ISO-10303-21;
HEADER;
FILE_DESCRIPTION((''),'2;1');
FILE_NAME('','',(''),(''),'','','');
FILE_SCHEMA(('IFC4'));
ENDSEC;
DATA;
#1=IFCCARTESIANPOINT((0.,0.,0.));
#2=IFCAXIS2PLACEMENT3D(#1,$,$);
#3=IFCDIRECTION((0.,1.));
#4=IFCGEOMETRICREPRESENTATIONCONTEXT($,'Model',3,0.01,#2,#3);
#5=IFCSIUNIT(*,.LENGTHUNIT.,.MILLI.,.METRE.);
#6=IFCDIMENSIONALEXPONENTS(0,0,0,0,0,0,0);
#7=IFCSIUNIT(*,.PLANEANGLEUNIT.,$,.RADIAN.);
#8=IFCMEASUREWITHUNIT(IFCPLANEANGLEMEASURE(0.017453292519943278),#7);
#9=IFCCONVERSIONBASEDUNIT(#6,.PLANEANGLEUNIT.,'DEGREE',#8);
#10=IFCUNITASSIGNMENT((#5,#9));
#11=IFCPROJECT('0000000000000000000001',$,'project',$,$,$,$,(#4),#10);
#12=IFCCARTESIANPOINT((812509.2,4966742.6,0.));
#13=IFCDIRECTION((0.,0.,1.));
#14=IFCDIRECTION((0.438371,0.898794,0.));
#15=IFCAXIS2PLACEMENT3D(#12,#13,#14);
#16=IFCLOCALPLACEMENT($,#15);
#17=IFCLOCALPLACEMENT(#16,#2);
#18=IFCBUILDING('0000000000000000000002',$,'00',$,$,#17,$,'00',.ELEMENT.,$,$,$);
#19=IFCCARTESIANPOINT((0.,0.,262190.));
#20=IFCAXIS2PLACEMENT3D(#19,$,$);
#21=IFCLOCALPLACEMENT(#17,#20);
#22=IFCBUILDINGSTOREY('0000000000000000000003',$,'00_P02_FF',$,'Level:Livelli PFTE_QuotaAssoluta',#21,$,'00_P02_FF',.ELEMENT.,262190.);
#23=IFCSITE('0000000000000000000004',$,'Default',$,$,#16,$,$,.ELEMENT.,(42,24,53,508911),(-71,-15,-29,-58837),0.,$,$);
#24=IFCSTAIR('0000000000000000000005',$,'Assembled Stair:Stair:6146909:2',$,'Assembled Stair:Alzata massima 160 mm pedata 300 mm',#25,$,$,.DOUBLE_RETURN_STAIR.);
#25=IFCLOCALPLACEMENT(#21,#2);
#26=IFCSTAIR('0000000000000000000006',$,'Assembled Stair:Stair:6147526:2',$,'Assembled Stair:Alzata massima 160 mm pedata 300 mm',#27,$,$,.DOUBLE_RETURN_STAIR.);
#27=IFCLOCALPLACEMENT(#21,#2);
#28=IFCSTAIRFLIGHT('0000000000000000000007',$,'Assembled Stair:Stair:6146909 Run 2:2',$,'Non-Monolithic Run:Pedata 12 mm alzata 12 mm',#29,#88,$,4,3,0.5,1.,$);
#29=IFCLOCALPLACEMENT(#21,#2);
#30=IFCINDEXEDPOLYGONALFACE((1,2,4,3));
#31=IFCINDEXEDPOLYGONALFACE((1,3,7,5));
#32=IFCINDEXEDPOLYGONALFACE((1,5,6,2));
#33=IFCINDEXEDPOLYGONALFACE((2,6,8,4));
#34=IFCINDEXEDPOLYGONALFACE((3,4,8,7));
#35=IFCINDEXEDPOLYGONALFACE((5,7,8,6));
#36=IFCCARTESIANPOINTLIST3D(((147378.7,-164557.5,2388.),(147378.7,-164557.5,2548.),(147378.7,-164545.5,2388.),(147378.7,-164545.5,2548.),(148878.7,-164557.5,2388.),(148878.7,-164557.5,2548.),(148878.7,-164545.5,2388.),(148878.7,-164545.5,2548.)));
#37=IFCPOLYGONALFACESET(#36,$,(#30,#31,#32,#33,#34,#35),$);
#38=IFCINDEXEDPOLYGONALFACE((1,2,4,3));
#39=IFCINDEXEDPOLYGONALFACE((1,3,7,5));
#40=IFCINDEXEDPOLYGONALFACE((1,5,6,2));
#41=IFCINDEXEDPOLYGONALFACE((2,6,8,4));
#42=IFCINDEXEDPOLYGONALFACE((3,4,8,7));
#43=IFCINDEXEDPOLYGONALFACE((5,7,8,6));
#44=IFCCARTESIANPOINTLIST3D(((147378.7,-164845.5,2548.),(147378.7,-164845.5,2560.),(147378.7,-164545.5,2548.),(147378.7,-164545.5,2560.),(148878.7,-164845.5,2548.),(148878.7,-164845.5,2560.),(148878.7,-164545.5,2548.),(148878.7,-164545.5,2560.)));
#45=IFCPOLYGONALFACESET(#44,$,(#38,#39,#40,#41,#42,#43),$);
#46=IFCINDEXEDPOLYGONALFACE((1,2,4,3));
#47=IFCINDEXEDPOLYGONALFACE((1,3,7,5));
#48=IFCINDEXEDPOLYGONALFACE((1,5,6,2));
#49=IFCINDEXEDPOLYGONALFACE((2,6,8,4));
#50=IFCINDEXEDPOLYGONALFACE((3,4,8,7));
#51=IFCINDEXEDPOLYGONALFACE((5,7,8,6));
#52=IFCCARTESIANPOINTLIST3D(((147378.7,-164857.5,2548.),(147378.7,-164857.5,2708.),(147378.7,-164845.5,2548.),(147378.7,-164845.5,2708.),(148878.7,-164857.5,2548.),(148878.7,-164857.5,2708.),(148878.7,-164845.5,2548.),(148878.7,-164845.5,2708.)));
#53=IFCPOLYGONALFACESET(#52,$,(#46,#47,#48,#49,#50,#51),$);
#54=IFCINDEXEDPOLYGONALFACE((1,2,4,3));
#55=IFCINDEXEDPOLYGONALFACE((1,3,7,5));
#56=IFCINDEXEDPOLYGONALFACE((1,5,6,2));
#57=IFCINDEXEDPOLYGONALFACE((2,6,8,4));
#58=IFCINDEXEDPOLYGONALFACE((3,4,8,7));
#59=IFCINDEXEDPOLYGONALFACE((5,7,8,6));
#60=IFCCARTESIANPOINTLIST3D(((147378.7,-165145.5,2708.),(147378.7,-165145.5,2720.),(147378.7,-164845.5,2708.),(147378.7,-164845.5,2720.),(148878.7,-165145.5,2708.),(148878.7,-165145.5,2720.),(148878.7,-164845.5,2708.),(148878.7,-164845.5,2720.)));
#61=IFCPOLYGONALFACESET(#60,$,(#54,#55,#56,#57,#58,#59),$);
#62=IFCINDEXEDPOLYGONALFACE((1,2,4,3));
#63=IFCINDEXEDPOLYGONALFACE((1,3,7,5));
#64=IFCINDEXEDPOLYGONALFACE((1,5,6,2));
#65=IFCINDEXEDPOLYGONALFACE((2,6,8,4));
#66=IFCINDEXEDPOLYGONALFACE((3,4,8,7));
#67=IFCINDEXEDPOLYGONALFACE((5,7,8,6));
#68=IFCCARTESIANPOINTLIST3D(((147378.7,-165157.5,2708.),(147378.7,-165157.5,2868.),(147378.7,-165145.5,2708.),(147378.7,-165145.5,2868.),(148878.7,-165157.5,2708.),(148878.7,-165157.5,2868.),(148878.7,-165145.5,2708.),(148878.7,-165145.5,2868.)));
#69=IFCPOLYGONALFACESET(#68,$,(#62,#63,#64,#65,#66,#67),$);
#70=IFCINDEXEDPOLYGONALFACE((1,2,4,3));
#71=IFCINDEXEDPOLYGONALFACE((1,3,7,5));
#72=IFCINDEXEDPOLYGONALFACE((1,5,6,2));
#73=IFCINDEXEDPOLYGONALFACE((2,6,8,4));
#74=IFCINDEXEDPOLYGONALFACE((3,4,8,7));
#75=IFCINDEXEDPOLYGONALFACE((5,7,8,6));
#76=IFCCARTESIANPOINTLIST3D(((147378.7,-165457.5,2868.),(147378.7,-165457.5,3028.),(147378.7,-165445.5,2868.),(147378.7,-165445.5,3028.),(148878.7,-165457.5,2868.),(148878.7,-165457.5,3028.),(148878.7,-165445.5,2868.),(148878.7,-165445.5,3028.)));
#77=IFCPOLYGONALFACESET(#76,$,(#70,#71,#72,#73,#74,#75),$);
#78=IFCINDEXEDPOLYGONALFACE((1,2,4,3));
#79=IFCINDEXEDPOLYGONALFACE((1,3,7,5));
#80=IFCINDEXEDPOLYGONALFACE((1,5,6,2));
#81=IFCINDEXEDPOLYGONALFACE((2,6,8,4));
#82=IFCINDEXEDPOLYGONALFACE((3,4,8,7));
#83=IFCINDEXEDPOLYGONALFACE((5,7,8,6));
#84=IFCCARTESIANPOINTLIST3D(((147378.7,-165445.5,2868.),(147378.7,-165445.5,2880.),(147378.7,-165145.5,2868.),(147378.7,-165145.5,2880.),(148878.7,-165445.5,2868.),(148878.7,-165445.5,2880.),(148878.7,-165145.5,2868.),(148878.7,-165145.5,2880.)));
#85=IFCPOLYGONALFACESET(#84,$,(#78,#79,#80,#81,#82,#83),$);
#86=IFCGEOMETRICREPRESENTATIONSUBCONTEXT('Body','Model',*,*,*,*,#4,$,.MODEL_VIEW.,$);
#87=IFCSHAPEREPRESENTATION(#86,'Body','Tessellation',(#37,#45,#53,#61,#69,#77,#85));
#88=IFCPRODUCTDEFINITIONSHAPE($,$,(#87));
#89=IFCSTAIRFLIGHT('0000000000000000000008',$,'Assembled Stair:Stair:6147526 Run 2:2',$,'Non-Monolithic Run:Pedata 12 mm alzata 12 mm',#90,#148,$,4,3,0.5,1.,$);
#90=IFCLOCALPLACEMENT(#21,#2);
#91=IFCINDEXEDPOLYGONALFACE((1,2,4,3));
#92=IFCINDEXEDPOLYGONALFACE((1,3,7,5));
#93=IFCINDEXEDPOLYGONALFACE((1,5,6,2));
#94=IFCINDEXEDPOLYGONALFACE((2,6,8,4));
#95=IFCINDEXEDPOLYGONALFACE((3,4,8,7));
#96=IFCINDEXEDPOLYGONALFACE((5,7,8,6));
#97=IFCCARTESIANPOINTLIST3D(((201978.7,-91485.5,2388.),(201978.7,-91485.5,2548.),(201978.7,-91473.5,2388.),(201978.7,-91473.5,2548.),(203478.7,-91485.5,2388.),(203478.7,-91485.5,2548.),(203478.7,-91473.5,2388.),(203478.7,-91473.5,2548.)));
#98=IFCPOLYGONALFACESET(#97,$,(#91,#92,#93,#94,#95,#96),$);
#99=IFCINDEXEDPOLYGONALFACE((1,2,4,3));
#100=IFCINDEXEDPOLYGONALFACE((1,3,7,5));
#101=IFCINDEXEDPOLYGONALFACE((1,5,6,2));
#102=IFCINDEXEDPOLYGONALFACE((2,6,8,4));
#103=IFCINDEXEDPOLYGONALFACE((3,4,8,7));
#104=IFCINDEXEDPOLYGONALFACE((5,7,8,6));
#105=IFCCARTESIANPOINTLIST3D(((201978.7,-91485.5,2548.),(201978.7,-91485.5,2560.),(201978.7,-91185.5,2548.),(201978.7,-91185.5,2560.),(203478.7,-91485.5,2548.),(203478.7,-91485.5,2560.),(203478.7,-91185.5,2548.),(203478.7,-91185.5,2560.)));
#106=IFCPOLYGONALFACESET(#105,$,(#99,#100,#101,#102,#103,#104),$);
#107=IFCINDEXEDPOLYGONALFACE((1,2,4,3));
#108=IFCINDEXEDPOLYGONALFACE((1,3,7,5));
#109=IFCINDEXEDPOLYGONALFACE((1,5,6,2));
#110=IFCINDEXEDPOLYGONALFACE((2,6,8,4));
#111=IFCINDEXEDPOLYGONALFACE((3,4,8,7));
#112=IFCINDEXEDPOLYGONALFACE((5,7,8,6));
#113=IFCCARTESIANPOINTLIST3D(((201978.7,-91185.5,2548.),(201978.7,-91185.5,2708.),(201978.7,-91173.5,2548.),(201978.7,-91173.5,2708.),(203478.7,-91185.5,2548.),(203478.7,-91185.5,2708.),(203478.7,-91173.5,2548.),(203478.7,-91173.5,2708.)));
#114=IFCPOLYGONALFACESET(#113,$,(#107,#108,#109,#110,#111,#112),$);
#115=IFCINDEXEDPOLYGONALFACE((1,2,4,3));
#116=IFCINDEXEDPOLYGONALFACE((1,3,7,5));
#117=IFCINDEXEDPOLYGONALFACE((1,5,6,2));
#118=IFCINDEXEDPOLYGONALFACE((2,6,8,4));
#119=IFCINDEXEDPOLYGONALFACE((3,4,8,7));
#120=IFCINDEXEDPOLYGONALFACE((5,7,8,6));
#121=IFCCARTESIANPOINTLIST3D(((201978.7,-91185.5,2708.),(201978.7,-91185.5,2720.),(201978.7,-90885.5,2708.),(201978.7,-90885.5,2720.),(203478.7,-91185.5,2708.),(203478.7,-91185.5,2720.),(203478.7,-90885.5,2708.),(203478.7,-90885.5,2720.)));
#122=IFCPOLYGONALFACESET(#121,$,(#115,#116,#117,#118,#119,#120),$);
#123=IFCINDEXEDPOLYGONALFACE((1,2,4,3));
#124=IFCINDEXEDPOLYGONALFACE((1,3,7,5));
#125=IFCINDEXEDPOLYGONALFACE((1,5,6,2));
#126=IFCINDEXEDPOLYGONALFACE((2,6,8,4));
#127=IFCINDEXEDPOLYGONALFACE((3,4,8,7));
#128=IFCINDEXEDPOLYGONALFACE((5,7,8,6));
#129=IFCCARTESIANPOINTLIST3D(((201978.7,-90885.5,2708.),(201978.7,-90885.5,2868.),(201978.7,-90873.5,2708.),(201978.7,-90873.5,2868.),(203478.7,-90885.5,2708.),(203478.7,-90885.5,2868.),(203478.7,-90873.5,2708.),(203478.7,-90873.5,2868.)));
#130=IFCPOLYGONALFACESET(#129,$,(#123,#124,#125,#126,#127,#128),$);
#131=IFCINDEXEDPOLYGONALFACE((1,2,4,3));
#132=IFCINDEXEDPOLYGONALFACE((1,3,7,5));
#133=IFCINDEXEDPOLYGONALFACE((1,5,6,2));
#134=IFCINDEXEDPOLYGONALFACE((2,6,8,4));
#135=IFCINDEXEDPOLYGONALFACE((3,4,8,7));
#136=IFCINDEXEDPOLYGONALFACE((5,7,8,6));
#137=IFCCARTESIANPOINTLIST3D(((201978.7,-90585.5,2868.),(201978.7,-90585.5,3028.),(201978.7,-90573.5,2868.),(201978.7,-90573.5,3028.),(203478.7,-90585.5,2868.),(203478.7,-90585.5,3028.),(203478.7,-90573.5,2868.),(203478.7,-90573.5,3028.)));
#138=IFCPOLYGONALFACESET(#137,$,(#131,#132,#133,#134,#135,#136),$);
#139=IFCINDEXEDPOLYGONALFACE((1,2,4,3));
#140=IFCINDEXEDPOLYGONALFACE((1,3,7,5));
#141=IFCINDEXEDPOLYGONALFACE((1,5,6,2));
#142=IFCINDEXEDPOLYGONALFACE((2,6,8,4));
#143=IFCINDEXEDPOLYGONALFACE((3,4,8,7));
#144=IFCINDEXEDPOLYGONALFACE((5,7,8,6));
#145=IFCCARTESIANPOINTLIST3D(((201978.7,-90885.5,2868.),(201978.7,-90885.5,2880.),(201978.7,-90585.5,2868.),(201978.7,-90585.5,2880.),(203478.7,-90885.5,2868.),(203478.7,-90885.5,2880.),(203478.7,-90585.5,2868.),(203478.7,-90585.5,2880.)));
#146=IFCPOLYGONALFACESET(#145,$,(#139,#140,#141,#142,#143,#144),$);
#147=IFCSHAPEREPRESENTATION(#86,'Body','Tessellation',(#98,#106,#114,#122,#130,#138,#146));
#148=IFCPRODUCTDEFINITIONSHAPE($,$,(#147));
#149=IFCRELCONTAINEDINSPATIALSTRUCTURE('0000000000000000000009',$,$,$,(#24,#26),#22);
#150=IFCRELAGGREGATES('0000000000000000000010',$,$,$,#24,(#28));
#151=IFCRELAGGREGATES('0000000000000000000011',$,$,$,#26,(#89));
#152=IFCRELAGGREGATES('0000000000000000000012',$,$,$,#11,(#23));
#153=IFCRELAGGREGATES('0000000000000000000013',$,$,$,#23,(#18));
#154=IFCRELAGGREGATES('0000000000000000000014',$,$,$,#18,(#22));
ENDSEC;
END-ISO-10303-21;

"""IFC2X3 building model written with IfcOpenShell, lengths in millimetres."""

from ifc_helpers import new_model, entity, si_unit, converted_unit, direction, frame, frame_2d, origin, origin_2d_with_axis, place, context, subcontext, project, spatial, rectangle, extrude, element, aggregate, save


model = new_model("IFC2X3")

# Units and contexts
model_context = context("Model", 3, precision=0.01, world=origin(), true_north=direction((0.0, 1.0)))
body_context = subcontext(model_context, "Body", "Model", "MODEL_VIEW")
ifc_project = project(units=[si_unit("LENGTHUNIT", "METRE", prefix="MILLI"), converted_unit("PLANEANGLEUNIT", "DEGREE", entity("IfcPlaneAngleMeasure", 0.017453292519943278), si_unit("PLANEANGLEUNIT", "RADIAN"), dimensions=[0, 0, 0, 0, 0, 0, 0])], contexts=[model_context])

# Site, building, storey
site_placement = place(None, frame((812509.2, 4966742.6, 0.0), z_axis=(0.0, 0.0, 1.0), x_axis=(0.438371, 0.898794, 0.0)))
site = spatial("IfcSite", under=ifc_project, at=site_placement, Name="Default", CompositionType="ELEMENT", RefLatitude=(42, 24, 53, 508911), RefLongitude=(-71, -15, -29, -58837), RefElevation=0.0)
building_placement = place(site_placement, origin())
building = spatial("IfcBuilding", under=site, at=building_placement, Name="00", LongName="00", CompositionType="ELEMENT")
storey_placement = place(building_placement, frame((0.0, 0.0, 262190.0)))
storey = spatial("IfcBuildingStorey", under=building, at=storey_placement, Name="00_P02_FF", ObjectType="Level:Livelli PFTE_QuotaAssoluta", LongName="00_P02_FF", CompositionType="ELEMENT", Elevation=262190.0)

# Stairs
stair_1_placement = place(storey_placement, origin())
stair_1 = element("IfcStair", 1, at=stair_1_placement, inside=storey, Name="Assembled Stair:Stair:6146909:2", ObjectType="Assembled Stair:Alzata massima 160 mm pedata 300 mm", ShapeType="DOUBLE_RETURN_STAIR")
stair_2_placement = place(storey_placement, origin())
stair_2 = element("IfcStair", 2, at=stair_2_placement, inside=storey, Name="Assembled Stair:Stair:6147526:2", ObjectType="Assembled Stair:Alzata massima 160 mm pedata 300 mm", ShapeType="DOUBLE_RETURN_STAIR")

# Stair flights
stair_flight_1_placement = place(stair_1_placement, origin())
stair_flight_1 = element("IfcStairFlight", 3, at=stair_flight_1_placement, Name="Assembled Stair:Stair:6146909 Run 2:2", ObjectType="Non-Monolithic Run:Pedata 12 mm alzata 12 mm", NumberOfRiser=4, NumberOfTreads=3, RiserHeight=0.5, TreadLength=1.0, context=body_context, shape_type="SweptSolid", body=[
    extrude(rectangle(XDim=1500.0, YDim=12.0, at=origin_2d_with_axis()), frame((148128.7, -164551.5, 2388.0)), (0.0, 0.0, 1.0), 160.0),
    extrude(rectangle(XDim=300.0, YDim=1500.0, at=origin_2d_with_axis()), frame((148128.7, -164695.5, 2548.0), z_axis=(0.0, 0.0, 1.0), x_axis=(0.0, 1.0, 0.0)), (0.0, 0.0, 1.0), 12.0),
    extrude(rectangle(XDim=1500.0, YDim=12.0, at=origin_2d_with_axis()), frame((148128.7, -164851.5, 2548.0)), (0.0, 0.0, 1.0), 160.0),
    extrude(rectangle(XDim=300.0, YDim=1500.0, at=frame_2d((0.0, 0.0), x_axis=(1.0, 0.0))), frame((148128.7, -164995.5, 2708.0), z_axis=(0.0, 0.0, 1.0), x_axis=(0.0, 1.0, 0.0)), (0.0, 0.0, 1.0), 12.0),
    extrude(rectangle(XDim=1500.0, YDim=12.0, at=origin_2d_with_axis()), frame((148128.7, -165151.5, 2708.0)), (0.0, 0.0, 1.0), 160.0),
    extrude(rectangle(XDim=1500.0, YDim=12.0, at=origin_2d_with_axis()), frame((148128.7, -165451.5, 2868.0)), (0.0, 0.0, 1.0), 160.0),
    extrude(rectangle(XDim=300.0, YDim=1500.0, at=frame_2d((0.0, 0.0), x_axis=(1.0, 0.0))), frame((148128.7, -165295.5, 2868.0), z_axis=(0.0, 0.0, 1.0), x_axis=(0.0, 1.0, 0.0)), (0.0, 0.0, 1.0), 12.0),
])
aggregate(stair_1, [stair_flight_1])
stair_flight_2_placement = place(stair_2_placement, origin())
stair_flight_2 = element("IfcStairFlight", 4, at=stair_flight_2_placement, Name="Assembled Stair:Stair:6147526 Run 2:2", ObjectType="Non-Monolithic Run:Pedata 12 mm alzata 12 mm", NumberOfRiser=4, NumberOfTreads=3, RiserHeight=0.5, TreadLength=1.0, context=body_context, shape_type="SweptSolid", body=[
    extrude(rectangle(XDim=1500.0, YDim=12.0, at=origin_2d_with_axis()), frame((202728.7, -91479.5, 2388.0), z_axis=(0.0, 0.0, 1.0), x_axis=(-1.0, 0.0, 0.0)), (0.0, 0.0, 1.0), 160.0),
    extrude(rectangle(XDim=300.0, YDim=1500.0, at=origin_2d_with_axis()), frame((202728.7, -91335.5, 2548.0), z_axis=(0.0, 0.0, 1.0), x_axis=(0.0, -1.0, 0.0)), (0.0, 0.0, 1.0), 12.0),
    extrude(rectangle(XDim=1500.0, YDim=12.0, at=origin_2d_with_axis()), frame((202728.7, -91179.5, 2548.0), z_axis=(0.0, 0.0, 1.0), x_axis=(-1.0, 0.0, 0.0)), (0.0, 0.0, 1.0), 160.0),
    extrude(rectangle(XDim=300.0, YDim=1500.0, at=frame_2d((0.0, 0.0), x_axis=(1.0, 0.0))), frame((202728.7, -91035.5, 2708.0), z_axis=(0.0, 0.0, 1.0), x_axis=(0.0, -1.0, 0.0)), (0.0, 0.0, 1.0), 12.0),
    extrude(rectangle(XDim=1500.0, YDim=12.0, at=origin_2d_with_axis()), frame((202728.7, -90879.5, 2708.0), z_axis=(0.0, 0.0, 1.0), x_axis=(-1.0, 0.0, 0.0)), (0.0, 0.0, 1.0), 160.0),
    extrude(rectangle(XDim=1500.0, YDim=12.0, at=origin_2d_with_axis()), frame((202728.7, -90579.5, 2868.0), z_axis=(0.0, 0.0, 1.0), x_axis=(-1.0, 0.0, 0.0)), (0.0, 0.0, 1.0), 160.0),
    extrude(rectangle(XDim=300.0, YDim=1500.0, at=frame_2d((0.0, 0.0), x_axis=(1.0, 0.0))), frame((202728.7, -90735.5, 2868.0), z_axis=(0.0, 0.0, 1.0), x_axis=(0.0, -1.0, 0.0)), (0.0, 0.0, 1.0), 12.0),
])
aggregate(stair_2, [stair_flight_2])

save(model, "model.ifc")
